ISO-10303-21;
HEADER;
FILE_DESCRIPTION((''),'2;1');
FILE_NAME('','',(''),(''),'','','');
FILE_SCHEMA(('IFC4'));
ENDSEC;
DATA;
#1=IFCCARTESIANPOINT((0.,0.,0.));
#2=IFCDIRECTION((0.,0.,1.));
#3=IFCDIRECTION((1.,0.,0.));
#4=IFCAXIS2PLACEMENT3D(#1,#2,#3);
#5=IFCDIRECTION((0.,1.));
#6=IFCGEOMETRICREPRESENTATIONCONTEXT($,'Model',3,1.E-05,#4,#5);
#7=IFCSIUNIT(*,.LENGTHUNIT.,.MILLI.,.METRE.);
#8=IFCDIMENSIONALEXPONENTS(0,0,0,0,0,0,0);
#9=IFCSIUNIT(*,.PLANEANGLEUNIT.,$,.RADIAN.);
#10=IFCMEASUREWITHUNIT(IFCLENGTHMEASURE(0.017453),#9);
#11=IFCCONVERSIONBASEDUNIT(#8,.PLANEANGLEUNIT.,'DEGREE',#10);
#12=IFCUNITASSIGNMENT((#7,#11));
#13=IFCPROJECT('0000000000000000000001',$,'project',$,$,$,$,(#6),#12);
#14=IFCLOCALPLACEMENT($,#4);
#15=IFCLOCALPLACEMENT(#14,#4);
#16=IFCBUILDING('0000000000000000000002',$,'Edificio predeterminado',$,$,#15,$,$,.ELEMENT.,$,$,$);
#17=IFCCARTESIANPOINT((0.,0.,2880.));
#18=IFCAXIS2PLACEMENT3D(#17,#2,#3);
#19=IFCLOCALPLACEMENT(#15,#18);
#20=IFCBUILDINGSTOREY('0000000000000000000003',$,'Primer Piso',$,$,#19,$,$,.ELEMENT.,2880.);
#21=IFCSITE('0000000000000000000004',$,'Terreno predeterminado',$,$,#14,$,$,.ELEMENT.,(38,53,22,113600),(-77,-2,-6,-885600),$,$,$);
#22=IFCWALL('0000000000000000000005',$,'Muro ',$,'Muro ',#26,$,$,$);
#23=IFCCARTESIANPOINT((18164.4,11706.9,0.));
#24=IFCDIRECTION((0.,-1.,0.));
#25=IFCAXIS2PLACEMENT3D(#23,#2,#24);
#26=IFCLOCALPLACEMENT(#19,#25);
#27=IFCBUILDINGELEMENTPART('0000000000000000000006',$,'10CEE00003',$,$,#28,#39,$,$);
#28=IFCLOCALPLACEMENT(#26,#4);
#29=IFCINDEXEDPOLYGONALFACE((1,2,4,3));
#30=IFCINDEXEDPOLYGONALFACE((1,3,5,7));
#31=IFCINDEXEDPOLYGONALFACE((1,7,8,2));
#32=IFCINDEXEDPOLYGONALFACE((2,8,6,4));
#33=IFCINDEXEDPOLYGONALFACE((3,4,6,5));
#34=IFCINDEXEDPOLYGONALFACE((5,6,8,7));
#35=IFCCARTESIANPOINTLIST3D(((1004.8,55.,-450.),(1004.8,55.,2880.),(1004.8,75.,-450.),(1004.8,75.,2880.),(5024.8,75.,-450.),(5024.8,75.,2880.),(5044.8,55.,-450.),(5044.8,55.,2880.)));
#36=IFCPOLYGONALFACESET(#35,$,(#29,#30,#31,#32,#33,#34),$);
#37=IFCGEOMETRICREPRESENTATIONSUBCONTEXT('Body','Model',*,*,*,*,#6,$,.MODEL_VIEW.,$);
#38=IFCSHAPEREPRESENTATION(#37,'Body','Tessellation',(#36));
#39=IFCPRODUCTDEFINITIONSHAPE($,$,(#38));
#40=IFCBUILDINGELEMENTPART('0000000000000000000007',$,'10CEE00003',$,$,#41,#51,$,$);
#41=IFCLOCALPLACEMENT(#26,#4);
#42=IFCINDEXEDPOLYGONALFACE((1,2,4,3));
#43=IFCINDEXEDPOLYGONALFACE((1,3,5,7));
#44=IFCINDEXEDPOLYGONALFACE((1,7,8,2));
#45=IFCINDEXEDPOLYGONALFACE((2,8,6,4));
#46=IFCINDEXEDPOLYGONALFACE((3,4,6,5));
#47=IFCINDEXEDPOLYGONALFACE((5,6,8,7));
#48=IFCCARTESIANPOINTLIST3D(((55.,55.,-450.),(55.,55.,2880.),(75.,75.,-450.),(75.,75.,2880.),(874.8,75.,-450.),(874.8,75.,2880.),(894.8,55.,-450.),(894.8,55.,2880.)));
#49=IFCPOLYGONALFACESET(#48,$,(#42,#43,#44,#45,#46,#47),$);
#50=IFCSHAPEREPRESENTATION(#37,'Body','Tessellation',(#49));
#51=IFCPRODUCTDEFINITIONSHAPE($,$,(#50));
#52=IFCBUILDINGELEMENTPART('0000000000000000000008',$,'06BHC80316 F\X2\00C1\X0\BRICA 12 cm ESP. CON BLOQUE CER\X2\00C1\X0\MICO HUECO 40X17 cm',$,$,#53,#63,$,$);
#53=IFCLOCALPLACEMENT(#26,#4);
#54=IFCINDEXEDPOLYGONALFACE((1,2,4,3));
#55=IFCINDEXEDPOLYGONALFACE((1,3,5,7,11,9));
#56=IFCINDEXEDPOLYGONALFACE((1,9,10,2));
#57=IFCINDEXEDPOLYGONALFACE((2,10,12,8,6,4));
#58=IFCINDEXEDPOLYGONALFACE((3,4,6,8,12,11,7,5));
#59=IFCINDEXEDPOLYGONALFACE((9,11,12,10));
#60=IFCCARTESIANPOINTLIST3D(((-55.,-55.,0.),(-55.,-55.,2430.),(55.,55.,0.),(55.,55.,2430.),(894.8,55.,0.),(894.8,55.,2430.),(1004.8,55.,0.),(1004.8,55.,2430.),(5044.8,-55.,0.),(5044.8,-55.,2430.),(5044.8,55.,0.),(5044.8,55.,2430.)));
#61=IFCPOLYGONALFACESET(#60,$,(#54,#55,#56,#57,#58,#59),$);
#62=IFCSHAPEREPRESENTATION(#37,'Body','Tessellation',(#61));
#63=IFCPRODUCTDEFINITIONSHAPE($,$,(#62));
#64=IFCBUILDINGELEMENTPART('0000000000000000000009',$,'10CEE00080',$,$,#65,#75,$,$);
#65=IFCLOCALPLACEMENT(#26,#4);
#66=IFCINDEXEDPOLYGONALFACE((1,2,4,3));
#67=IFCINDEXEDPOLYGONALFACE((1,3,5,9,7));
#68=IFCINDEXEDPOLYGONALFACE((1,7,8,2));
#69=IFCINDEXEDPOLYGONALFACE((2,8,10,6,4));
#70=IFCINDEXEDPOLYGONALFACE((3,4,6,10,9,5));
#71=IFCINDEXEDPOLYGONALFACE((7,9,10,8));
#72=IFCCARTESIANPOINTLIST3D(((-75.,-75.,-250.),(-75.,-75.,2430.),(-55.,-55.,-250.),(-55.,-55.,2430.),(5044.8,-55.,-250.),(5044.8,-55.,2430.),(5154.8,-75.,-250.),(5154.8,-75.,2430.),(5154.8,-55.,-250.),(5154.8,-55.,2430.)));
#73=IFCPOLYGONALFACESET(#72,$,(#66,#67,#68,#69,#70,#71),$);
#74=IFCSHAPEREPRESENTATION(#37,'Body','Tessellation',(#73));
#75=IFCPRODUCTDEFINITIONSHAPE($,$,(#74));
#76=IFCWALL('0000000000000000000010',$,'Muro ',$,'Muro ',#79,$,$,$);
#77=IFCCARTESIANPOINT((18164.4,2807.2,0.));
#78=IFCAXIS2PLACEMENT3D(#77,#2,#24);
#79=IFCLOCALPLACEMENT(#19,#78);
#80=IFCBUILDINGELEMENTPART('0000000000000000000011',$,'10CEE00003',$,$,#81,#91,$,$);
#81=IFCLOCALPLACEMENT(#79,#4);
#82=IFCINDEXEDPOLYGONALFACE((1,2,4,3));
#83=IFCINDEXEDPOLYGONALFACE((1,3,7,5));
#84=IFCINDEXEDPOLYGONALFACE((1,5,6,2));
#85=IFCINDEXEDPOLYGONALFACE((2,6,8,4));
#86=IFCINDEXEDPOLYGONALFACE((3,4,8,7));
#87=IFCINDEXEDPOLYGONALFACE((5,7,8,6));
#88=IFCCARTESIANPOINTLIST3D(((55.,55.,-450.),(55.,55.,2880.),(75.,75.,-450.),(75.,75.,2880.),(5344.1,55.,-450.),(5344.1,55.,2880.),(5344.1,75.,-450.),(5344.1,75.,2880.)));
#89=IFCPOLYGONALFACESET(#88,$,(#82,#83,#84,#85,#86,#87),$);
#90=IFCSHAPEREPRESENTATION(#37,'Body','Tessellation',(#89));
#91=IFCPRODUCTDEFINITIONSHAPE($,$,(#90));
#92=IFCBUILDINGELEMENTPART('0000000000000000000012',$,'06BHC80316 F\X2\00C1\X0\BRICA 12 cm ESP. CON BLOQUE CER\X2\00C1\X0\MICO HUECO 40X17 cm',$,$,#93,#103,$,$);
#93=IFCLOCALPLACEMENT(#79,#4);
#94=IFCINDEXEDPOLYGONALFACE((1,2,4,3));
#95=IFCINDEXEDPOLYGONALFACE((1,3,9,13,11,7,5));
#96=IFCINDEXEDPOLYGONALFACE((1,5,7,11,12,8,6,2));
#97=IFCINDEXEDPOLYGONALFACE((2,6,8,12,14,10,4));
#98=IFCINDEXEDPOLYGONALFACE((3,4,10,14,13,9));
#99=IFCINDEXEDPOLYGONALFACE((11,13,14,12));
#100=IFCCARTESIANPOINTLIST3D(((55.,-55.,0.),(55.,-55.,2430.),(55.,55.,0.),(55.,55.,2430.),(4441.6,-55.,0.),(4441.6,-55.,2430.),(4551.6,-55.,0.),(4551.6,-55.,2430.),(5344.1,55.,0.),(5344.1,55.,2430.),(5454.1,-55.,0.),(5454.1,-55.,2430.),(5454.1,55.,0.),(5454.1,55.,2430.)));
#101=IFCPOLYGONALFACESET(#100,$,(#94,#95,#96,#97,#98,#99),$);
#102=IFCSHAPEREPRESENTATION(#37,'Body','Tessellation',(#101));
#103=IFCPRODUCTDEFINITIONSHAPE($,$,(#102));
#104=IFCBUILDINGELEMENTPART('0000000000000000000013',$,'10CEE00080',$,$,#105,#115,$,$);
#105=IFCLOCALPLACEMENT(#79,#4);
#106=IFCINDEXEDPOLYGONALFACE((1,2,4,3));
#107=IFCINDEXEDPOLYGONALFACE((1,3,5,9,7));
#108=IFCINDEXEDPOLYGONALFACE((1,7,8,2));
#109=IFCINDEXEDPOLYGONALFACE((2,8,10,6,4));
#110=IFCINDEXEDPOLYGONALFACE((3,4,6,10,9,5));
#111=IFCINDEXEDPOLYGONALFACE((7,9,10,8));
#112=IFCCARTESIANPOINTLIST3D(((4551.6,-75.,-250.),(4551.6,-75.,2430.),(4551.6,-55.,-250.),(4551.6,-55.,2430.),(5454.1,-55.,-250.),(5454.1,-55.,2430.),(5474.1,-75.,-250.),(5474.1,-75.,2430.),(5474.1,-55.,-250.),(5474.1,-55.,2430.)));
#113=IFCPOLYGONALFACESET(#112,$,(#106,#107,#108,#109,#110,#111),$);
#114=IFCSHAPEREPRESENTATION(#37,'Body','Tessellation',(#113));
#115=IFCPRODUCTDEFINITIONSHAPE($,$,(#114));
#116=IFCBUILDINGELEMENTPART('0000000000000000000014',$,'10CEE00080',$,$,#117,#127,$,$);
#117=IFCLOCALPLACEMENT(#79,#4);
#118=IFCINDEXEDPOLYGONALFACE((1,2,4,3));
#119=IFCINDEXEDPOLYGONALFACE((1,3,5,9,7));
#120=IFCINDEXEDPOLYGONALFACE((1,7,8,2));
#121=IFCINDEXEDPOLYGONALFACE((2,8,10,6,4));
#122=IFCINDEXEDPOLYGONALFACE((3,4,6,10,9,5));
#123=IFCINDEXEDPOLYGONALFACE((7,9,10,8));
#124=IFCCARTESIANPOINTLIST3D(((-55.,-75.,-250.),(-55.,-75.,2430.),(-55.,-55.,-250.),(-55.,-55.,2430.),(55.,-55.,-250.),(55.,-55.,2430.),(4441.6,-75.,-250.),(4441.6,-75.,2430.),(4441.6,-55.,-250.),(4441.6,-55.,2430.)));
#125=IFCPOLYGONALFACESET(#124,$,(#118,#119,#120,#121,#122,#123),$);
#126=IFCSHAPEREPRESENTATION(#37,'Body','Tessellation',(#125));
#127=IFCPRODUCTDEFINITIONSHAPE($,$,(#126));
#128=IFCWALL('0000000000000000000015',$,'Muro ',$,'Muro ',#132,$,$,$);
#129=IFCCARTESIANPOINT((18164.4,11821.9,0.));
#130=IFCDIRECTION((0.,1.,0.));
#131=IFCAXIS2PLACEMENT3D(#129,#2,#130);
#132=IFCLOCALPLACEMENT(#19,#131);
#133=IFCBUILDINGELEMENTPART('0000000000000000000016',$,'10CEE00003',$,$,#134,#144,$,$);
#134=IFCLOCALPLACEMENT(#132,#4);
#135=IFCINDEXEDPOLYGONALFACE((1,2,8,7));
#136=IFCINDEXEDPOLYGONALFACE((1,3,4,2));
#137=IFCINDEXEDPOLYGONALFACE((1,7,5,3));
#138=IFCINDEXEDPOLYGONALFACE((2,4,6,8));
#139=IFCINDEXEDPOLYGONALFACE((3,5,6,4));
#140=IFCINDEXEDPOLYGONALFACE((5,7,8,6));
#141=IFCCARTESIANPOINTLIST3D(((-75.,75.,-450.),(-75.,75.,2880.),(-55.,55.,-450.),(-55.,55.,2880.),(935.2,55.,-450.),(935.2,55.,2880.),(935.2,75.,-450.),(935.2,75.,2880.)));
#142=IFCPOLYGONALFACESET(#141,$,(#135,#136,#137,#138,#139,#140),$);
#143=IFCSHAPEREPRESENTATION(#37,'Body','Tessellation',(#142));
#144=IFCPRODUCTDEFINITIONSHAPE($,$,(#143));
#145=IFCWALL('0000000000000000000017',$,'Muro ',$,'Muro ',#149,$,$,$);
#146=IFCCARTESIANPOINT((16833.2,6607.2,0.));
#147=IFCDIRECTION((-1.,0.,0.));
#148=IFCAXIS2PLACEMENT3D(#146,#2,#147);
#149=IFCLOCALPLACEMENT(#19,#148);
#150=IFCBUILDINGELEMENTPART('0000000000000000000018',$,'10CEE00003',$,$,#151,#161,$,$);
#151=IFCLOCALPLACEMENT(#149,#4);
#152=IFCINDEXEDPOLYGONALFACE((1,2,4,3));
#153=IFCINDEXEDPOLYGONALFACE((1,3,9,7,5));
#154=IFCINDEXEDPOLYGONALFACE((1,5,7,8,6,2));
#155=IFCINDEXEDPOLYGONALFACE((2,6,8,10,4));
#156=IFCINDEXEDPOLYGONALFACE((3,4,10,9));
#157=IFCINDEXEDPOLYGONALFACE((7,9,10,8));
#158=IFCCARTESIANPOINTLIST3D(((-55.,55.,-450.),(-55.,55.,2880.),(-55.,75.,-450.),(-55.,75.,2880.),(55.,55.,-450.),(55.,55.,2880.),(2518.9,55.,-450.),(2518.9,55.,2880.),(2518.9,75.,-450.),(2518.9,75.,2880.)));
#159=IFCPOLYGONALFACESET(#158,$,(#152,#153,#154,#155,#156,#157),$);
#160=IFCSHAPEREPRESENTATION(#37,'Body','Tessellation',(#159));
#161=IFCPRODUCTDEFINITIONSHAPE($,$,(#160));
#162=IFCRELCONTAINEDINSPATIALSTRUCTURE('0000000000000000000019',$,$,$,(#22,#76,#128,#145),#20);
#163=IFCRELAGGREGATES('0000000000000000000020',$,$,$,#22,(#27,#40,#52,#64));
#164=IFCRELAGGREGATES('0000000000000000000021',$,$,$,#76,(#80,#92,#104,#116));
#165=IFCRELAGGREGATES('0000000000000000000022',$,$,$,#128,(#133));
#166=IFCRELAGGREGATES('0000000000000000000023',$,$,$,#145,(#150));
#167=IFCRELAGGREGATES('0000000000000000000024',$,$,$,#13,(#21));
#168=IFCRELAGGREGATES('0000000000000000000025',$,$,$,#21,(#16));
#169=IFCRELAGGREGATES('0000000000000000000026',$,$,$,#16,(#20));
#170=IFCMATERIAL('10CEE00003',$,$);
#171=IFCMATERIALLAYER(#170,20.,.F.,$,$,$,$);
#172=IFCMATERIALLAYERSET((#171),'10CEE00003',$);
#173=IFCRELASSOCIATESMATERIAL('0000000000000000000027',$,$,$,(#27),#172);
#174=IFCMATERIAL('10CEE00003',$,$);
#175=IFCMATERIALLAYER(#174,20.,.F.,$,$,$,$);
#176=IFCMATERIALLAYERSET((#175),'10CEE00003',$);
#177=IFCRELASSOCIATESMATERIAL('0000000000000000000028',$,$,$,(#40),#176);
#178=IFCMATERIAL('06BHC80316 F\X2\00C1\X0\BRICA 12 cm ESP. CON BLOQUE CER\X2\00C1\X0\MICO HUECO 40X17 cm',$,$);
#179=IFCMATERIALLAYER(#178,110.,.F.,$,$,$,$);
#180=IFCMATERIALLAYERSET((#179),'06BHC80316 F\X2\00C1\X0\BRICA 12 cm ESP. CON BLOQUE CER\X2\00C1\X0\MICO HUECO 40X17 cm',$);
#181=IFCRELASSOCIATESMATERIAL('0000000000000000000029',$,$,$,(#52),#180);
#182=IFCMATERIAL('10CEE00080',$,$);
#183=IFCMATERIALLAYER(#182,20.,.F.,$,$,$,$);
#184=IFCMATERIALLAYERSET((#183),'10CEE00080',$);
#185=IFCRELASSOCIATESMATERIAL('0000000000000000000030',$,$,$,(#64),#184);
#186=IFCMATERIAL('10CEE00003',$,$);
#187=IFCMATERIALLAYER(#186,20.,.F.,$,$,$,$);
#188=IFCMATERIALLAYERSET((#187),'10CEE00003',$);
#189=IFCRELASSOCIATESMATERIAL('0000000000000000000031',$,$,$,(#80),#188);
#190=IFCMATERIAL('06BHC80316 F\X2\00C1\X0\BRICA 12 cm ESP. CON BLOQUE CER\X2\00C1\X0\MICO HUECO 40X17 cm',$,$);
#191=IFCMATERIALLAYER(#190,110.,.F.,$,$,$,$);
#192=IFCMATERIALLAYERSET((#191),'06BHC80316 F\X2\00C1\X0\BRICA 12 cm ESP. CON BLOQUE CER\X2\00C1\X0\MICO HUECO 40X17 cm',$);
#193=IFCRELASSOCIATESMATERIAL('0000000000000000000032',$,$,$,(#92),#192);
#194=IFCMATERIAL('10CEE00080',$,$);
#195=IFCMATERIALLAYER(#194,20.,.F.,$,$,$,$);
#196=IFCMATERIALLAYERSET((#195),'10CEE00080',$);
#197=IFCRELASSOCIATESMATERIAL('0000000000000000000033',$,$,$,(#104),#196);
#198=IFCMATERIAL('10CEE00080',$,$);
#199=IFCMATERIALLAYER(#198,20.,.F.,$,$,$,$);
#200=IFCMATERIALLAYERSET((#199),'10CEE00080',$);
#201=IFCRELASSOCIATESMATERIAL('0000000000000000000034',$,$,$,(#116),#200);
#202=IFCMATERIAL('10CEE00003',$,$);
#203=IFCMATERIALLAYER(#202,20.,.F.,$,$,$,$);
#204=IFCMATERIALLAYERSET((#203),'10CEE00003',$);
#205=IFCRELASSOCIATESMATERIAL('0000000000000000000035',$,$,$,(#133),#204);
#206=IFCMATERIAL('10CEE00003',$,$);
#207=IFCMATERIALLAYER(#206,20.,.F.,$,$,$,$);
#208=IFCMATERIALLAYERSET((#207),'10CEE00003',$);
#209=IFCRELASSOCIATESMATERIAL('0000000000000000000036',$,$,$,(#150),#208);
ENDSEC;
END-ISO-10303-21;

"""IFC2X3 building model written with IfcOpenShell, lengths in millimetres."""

from ifc_helpers import new_model, entity, si_unit, converted_unit, direction, frame, origin_with_axes, place, context, subcontext, project, spatial, polyline, outline, extrude, material, layer, layer_set, layer_usage, element, aggregate, save


model = new_model("IFC2X3")

# Units and contexts
model_context = context("Model", 3, precision=1e-05, world=origin_with_axes(), true_north=direction((0.0, 1.0)))
body_context = subcontext(model_context, "Body", "Model", "MODEL_VIEW")
ifc_project = project(units=[si_unit("LENGTHUNIT", "METRE", prefix="MILLI"), converted_unit("PLANEANGLEUNIT", "DEGREE", entity("IfcLengthMeasure", 0.017453), si_unit("PLANEANGLEUNIT", "RADIAN"), dimensions=[0, 0, 0, 0, 0, 0, 0])], contexts=[model_context])

# Site, building, storey
site_placement = place(None, origin_with_axes())
site = spatial("IfcSite", under=ifc_project, at=site_placement, Name="Terreno predeterminado", CompositionType="ELEMENT", RefLatitude=(38, 53, 22, 113600), RefLongitude=(-77, -2, -6, -885600))
building_placement = place(site_placement, origin_with_axes())
building = spatial("IfcBuilding", under=site, at=building_placement, Name="Edificio predeterminado", CompositionType="ELEMENT")
storey_placement = place(building_placement, frame((0.0, 0.0, 2880.0), z_axis=(0.0, 0.0, 1.0), x_axis=(1.0, 0.0, 0.0)))
storey = spatial("IfcBuildingStorey", under=building, at=storey_placement, Name="Primer Piso", CompositionType="ELEMENT", Elevation=2880.0)

# Walls, building element parts
wall_1_placement = place(storey_placement, frame((18164.4, 11706.9, 0.0), z_axis=(0.0, 0.0, 1.0), x_axis=(0.0, -1.0, 0.0)))
wall_1 = element("IfcWall", 1, at=wall_1_placement, inside=storey, Name="Muro ", ObjectType="Muro ")
ifc_material_1 = material(Name="10CEE00003")
ifc_layer_1 = layer(ifc_material_1, 20.0, ventilated=False)
ifc_layer_set_1 = layer_set([ifc_layer_1], Name="10CEE00003")
ifc_layer_usage_1 = layer_usage(ifc_layer_set_1, "AXIS2", "NEGATIVE", -75.0)
building_element_part_1_placement = place(wall_1_placement, origin_with_axes())
building_element_part_1 = element("IfcBuildingElementPart", 2, at=building_element_part_1_placement, material=ifc_layer_usage_1, Name="10CEE00003", context=body_context, shape_type="SweptSolid", body=[
    extrude(outline(polyline([(5024.8, 75.0), (5044.8, 55.0), (1004.8, 55.0), (1004.8, 75.0), (5024.8, 75.0)])), frame((0.0, 0.0, -450.0), z_axis=(0.0, 0.0, 1.0), x_axis=(1.0, 0.0, 0.0)), (0.0, 0.0, 1.0), 3330.0),
])
ifc_material_2 = material(Name="10CEE00003")
ifc_layer_2 = layer(ifc_material_2, 20.0, ventilated=False)
ifc_layer_set_2 = layer_set([ifc_layer_2], Name="10CEE00003")
ifc_layer_usage_2 = layer_usage(ifc_layer_set_2, "AXIS2", "NEGATIVE", -75.0)
building_element_part_2_placement = place(wall_1_placement, origin_with_axes())
building_element_part_2 = element("IfcBuildingElementPart", 3, at=building_element_part_2_placement, material=ifc_layer_usage_2, Name="10CEE00003", context=body_context, shape_type="SweptSolid", body=[
    extrude(outline(polyline([(874.8, 75.0), (894.8, 55.0), (55.0, 55.0), (75.0, 75.0), (874.8, 75.0)])), frame((0.0, 0.0, -450.0), z_axis=(0.0, 0.0, 1.0), x_axis=(1.0, 0.0, 0.0)), (0.0, 0.0, 1.0), 3330.0),
])
ifc_material_3 = material(Name="06BHC80316 FÁBRICA 12 cm ESP. CON BLOQUE CERÁMICO HUECO 40X17 cm")
ifc_layer_3 = layer(ifc_material_3, 110.0, ventilated=False)
ifc_layer_set_3 = layer_set([ifc_layer_3], Name="06BHC80316 FÁBRICA 12 cm ESP. CON BLOQUE CERÁMICO HUECO 40X17 cm")
ifc_layer_usage_3 = layer_usage(ifc_layer_set_3, "AXIS2", "NEGATIVE", -55.0)
building_element_part_3_placement = place(wall_1_placement, origin_with_axes())
building_element_part_3 = element("IfcBuildingElementPart", 4, at=building_element_part_3_placement, material=ifc_layer_usage_3, Name="06BHC80316 FÁBRICA 12 cm ESP. CON BLOQUE CERÁMICO HUECO 40X17 cm", context=body_context, shape_type="SweptSolid", body=[
    extrude(outline(polyline([(5044.8, 55.0), (5044.8, -55.0), (-55.0, -55.0), (55.0, 55.0), (894.8, 55.0), (1004.8, 55.0), (5044.8, 55.0)])), origin_with_axes(), (0.0, 0.0, 1.0), 2430.0),
])
ifc_material_4 = material(Name="10CEE00080")
ifc_layer_4 = layer(ifc_material_4, 20.0, ventilated=False)
ifc_layer_set_4 = layer_set([ifc_layer_4], Name="10CEE00080")
ifc_layer_usage_4 = layer_usage(ifc_layer_set_4, "AXIS2", "NEGATIVE", 55.0)
building_element_part_4_placement = place(wall_1_placement, origin_with_axes())
building_element_part_4 = element("IfcBuildingElementPart", 5, at=building_element_part_4_placement, material=ifc_layer_usage_4, Name="10CEE00080", context=body_context, shape_type="SweptSolid", body=[
    extrude(outline(polyline([(5154.8, -55.0), (5154.8, -75.0), (-75.0, -75.0), (-55.0, -55.0), (5044.8, -55.0), (5154.8, -55.0)])), frame((0.0, 0.0, -250.0), z_axis=(0.0, 0.0, 1.0), x_axis=(1.0, 0.0, 0.0)), (0.0, 0.0, 1.0), 2680.0),
])
aggregate(wall_1, [building_element_part_1, building_element_part_2, building_element_part_3, building_element_part_4])
wall_2_placement = place(storey_placement, frame((18164.4, 2807.2, 0.0), z_axis=(0.0, 0.0, 1.0), x_axis=(0.0, -1.0, 0.0)))
wall_2 = element("IfcWall", 6, at=wall_2_placement, inside=storey, Name="Muro ", ObjectType="Muro ")
ifc_material_5 = material(Name="10CEE00003")
ifc_layer_5 = layer(ifc_material_5, 20.0, ventilated=False)
ifc_layer_set_5 = layer_set([ifc_layer_5], Name="10CEE00003")
ifc_layer_usage_5 = layer_usage(ifc_layer_set_5, "AXIS2", "NEGATIVE", -75.0)
building_element_part_5_placement = place(wall_2_placement, origin_with_axes())
building_element_part_5 = element("IfcBuildingElementPart", 7, at=building_element_part_5_placement, material=ifc_layer_usage_5, Name="10CEE00003", context=body_context, shape_type="SweptSolid", body=[
    extrude(outline(polyline([(5344.1, 75.0), (5344.1, 55.0), (55.0, 55.0), (75.0, 75.0), (5344.1, 75.0)])), frame((0.0, 0.0, -450.0), z_axis=(0.0, 0.0, 1.0), x_axis=(1.0, 0.0, 0.0)), (0.0, 0.0, 1.0), 3330.0),
])
ifc_material_6 = material(Name="06BHC80316 FÁBRICA 12 cm ESP. CON BLOQUE CERÁMICO HUECO 40X17 cm")
ifc_layer_6 = layer(ifc_material_6, 110.0, ventilated=False)
ifc_layer_set_6 = layer_set([ifc_layer_6], Name="06BHC80316 FÁBRICA 12 cm ESP. CON BLOQUE CERÁMICO HUECO 40X17 cm")
ifc_layer_usage_6 = layer_usage(ifc_layer_set_6, "AXIS2", "NEGATIVE", -55.0)
building_element_part_6_placement = place(wall_2_placement, origin_with_axes())
building_element_part_6 = element("IfcBuildingElementPart", 8, at=building_element_part_6_placement, material=ifc_layer_usage_6, Name="06BHC80316 FÁBRICA 12 cm ESP. CON BLOQUE CERÁMICO HUECO 40X17 cm", context=body_context, shape_type="SweptSolid", body=[
    extrude(outline(polyline([(5454.1, 55.0), (5454.1, -55.0), (4551.6, -55.0), (4441.6, -55.0), (55.0, -55.0), (55.0, 55.0), (5344.1, 55.0), (5454.1, 55.0)])), origin_with_axes(), (0.0, 0.0, 1.0), 2430.0),
])
ifc_material_7 = material(Name="10CEE00080")
ifc_layer_7 = layer(ifc_material_7, 20.0, ventilated=False)
ifc_layer_set_7 = layer_set([ifc_layer_7], Name="10CEE00080")
ifc_layer_usage_7 = layer_usage(ifc_layer_set_7, "AXIS2", "NEGATIVE", 55.0)
building_element_part_7_placement = place(wall_2_placement, origin_with_axes())
building_element_part_7 = element("IfcBuildingElementPart", 9, at=building_element_part_7_placement, material=ifc_layer_usage_7, Name="10CEE00080", context=body_context, shape_type="SweptSolid", body=[
    extrude(outline(polyline([(5474.1, -55.0), (5474.1, -75.0), (4551.6, -75.0), (4551.6, -55.0), (5454.1, -55.0), (5474.1, -55.0)])), frame((0.0, 0.0, -250.0), z_axis=(0.0, 0.0, 1.0), x_axis=(1.0, 0.0, 0.0)), (0.0, 0.0, 1.0), 2680.0),
])
ifc_material_8 = material(Name="10CEE00080")
ifc_layer_8 = layer(ifc_material_8, 20.0, ventilated=False)
ifc_layer_set_8 = layer_set([ifc_layer_8], Name="10CEE00080")
ifc_layer_usage_8 = layer_usage(ifc_layer_set_8, "AXIS2", "NEGATIVE", 55.0)
building_element_part_8_placement = place(wall_2_placement, origin_with_axes())
building_element_part_8 = element("IfcBuildingElementPart", 10, at=building_element_part_8_placement, material=ifc_layer_usage_8, Name="10CEE00080", context=body_context, shape_type="SweptSolid", body=[
    extrude(outline(polyline([(4441.6, -55.0), (4441.6, -75.0), (-55.0, -75.0), (-55.0, -55.0), (55.0, -55.0), (4441.6, -55.0)])), frame((0.0, 0.0, -250.0), z_axis=(0.0, 0.0, 1.0), x_axis=(1.0, 0.0, 0.0)), (0.0, 0.0, 1.0), 2680.0),
])
aggregate(wall_2, [building_element_part_5, building_element_part_6, building_element_part_7, building_element_part_8])

# Wall, building element part
wall_3_placement = place(storey_placement, frame((18164.4, 11821.9, 0.0), z_axis=(0.0, 0.0, 1.0), x_axis=(0.0, 1.0, 0.0)))
wall_3 = element("IfcWall", 11, at=wall_3_placement, inside=storey, Name="Muro ", ObjectType="Muro ")
ifc_material_9 = material(Name="10CEE00003")
ifc_layer_9 = layer(ifc_material_9, 20.0, ventilated=False)
ifc_layer_set_9 = layer_set([ifc_layer_9], Name="10CEE00003")
ifc_layer_usage_9 = layer_usage(ifc_layer_set_9, "AXIS2", "NEGATIVE", -75.0)
building_element_part_9_placement = place(wall_3_placement, origin_with_axes())
building_element_part_9 = element("IfcBuildingElementPart", 12, at=building_element_part_9_placement, material=ifc_layer_usage_9, Name="10CEE00003", context=body_context, shape_type="SweptSolid", body=[
    extrude(outline(polyline([(935.2, 75.0), (935.2, 55.0), (-55.0, 55.0), (-75.0, 75.0), (935.2, 75.0)])), frame((0.0, 0.0, -450.0), z_axis=(0.0, 0.0, 1.0), x_axis=(1.0, 0.0, 0.0)), (0.0, 0.0, 1.0), 3330.0),
])
aggregate(wall_3, [building_element_part_9])

# Wall, building element part
wall_4_placement = place(storey_placement, frame((16833.2, 6607.2, 0.0), z_axis=(0.0, 0.0, 1.0), x_axis=(-1.0, 0.0, 0.0)))
wall_4 = element("IfcWall", 13, at=wall_4_placement, inside=storey, Name="Muro ", ObjectType="Muro ")
ifc_material_10 = material(Name="10CEE00003")
ifc_layer_10 = layer(ifc_material_10, 20.0, ventilated=False)
ifc_layer_set_10 = layer_set([ifc_layer_10], Name="10CEE00003")
ifc_layer_usage_10 = layer_usage(ifc_layer_set_10, "AXIS2", "NEGATIVE", -75.0)
building_element_part_10_placement = place(wall_4_placement, origin_with_axes())
building_element_part_10 = element("IfcBuildingElementPart", 14, at=building_element_part_10_placement, material=ifc_layer_usage_10, Name="10CEE00003", context=body_context, shape_type="SweptSolid", body=[
    extrude(outline(polyline([(2518.9, 75.0), (2518.9, 55.0), (55.0, 55.0), (-55.0, 55.0), (-55.0, 75.0), (2518.9, 75.0)])), frame((0.0, 0.0, -450.0), z_axis=(0.0, 0.0, 1.0), x_axis=(1.0, 0.0, 0.0)), (0.0, 0.0, 1.0), 3330.0),
])
aggregate(wall_4, [building_element_part_10])

save(model, "model.ifc")
